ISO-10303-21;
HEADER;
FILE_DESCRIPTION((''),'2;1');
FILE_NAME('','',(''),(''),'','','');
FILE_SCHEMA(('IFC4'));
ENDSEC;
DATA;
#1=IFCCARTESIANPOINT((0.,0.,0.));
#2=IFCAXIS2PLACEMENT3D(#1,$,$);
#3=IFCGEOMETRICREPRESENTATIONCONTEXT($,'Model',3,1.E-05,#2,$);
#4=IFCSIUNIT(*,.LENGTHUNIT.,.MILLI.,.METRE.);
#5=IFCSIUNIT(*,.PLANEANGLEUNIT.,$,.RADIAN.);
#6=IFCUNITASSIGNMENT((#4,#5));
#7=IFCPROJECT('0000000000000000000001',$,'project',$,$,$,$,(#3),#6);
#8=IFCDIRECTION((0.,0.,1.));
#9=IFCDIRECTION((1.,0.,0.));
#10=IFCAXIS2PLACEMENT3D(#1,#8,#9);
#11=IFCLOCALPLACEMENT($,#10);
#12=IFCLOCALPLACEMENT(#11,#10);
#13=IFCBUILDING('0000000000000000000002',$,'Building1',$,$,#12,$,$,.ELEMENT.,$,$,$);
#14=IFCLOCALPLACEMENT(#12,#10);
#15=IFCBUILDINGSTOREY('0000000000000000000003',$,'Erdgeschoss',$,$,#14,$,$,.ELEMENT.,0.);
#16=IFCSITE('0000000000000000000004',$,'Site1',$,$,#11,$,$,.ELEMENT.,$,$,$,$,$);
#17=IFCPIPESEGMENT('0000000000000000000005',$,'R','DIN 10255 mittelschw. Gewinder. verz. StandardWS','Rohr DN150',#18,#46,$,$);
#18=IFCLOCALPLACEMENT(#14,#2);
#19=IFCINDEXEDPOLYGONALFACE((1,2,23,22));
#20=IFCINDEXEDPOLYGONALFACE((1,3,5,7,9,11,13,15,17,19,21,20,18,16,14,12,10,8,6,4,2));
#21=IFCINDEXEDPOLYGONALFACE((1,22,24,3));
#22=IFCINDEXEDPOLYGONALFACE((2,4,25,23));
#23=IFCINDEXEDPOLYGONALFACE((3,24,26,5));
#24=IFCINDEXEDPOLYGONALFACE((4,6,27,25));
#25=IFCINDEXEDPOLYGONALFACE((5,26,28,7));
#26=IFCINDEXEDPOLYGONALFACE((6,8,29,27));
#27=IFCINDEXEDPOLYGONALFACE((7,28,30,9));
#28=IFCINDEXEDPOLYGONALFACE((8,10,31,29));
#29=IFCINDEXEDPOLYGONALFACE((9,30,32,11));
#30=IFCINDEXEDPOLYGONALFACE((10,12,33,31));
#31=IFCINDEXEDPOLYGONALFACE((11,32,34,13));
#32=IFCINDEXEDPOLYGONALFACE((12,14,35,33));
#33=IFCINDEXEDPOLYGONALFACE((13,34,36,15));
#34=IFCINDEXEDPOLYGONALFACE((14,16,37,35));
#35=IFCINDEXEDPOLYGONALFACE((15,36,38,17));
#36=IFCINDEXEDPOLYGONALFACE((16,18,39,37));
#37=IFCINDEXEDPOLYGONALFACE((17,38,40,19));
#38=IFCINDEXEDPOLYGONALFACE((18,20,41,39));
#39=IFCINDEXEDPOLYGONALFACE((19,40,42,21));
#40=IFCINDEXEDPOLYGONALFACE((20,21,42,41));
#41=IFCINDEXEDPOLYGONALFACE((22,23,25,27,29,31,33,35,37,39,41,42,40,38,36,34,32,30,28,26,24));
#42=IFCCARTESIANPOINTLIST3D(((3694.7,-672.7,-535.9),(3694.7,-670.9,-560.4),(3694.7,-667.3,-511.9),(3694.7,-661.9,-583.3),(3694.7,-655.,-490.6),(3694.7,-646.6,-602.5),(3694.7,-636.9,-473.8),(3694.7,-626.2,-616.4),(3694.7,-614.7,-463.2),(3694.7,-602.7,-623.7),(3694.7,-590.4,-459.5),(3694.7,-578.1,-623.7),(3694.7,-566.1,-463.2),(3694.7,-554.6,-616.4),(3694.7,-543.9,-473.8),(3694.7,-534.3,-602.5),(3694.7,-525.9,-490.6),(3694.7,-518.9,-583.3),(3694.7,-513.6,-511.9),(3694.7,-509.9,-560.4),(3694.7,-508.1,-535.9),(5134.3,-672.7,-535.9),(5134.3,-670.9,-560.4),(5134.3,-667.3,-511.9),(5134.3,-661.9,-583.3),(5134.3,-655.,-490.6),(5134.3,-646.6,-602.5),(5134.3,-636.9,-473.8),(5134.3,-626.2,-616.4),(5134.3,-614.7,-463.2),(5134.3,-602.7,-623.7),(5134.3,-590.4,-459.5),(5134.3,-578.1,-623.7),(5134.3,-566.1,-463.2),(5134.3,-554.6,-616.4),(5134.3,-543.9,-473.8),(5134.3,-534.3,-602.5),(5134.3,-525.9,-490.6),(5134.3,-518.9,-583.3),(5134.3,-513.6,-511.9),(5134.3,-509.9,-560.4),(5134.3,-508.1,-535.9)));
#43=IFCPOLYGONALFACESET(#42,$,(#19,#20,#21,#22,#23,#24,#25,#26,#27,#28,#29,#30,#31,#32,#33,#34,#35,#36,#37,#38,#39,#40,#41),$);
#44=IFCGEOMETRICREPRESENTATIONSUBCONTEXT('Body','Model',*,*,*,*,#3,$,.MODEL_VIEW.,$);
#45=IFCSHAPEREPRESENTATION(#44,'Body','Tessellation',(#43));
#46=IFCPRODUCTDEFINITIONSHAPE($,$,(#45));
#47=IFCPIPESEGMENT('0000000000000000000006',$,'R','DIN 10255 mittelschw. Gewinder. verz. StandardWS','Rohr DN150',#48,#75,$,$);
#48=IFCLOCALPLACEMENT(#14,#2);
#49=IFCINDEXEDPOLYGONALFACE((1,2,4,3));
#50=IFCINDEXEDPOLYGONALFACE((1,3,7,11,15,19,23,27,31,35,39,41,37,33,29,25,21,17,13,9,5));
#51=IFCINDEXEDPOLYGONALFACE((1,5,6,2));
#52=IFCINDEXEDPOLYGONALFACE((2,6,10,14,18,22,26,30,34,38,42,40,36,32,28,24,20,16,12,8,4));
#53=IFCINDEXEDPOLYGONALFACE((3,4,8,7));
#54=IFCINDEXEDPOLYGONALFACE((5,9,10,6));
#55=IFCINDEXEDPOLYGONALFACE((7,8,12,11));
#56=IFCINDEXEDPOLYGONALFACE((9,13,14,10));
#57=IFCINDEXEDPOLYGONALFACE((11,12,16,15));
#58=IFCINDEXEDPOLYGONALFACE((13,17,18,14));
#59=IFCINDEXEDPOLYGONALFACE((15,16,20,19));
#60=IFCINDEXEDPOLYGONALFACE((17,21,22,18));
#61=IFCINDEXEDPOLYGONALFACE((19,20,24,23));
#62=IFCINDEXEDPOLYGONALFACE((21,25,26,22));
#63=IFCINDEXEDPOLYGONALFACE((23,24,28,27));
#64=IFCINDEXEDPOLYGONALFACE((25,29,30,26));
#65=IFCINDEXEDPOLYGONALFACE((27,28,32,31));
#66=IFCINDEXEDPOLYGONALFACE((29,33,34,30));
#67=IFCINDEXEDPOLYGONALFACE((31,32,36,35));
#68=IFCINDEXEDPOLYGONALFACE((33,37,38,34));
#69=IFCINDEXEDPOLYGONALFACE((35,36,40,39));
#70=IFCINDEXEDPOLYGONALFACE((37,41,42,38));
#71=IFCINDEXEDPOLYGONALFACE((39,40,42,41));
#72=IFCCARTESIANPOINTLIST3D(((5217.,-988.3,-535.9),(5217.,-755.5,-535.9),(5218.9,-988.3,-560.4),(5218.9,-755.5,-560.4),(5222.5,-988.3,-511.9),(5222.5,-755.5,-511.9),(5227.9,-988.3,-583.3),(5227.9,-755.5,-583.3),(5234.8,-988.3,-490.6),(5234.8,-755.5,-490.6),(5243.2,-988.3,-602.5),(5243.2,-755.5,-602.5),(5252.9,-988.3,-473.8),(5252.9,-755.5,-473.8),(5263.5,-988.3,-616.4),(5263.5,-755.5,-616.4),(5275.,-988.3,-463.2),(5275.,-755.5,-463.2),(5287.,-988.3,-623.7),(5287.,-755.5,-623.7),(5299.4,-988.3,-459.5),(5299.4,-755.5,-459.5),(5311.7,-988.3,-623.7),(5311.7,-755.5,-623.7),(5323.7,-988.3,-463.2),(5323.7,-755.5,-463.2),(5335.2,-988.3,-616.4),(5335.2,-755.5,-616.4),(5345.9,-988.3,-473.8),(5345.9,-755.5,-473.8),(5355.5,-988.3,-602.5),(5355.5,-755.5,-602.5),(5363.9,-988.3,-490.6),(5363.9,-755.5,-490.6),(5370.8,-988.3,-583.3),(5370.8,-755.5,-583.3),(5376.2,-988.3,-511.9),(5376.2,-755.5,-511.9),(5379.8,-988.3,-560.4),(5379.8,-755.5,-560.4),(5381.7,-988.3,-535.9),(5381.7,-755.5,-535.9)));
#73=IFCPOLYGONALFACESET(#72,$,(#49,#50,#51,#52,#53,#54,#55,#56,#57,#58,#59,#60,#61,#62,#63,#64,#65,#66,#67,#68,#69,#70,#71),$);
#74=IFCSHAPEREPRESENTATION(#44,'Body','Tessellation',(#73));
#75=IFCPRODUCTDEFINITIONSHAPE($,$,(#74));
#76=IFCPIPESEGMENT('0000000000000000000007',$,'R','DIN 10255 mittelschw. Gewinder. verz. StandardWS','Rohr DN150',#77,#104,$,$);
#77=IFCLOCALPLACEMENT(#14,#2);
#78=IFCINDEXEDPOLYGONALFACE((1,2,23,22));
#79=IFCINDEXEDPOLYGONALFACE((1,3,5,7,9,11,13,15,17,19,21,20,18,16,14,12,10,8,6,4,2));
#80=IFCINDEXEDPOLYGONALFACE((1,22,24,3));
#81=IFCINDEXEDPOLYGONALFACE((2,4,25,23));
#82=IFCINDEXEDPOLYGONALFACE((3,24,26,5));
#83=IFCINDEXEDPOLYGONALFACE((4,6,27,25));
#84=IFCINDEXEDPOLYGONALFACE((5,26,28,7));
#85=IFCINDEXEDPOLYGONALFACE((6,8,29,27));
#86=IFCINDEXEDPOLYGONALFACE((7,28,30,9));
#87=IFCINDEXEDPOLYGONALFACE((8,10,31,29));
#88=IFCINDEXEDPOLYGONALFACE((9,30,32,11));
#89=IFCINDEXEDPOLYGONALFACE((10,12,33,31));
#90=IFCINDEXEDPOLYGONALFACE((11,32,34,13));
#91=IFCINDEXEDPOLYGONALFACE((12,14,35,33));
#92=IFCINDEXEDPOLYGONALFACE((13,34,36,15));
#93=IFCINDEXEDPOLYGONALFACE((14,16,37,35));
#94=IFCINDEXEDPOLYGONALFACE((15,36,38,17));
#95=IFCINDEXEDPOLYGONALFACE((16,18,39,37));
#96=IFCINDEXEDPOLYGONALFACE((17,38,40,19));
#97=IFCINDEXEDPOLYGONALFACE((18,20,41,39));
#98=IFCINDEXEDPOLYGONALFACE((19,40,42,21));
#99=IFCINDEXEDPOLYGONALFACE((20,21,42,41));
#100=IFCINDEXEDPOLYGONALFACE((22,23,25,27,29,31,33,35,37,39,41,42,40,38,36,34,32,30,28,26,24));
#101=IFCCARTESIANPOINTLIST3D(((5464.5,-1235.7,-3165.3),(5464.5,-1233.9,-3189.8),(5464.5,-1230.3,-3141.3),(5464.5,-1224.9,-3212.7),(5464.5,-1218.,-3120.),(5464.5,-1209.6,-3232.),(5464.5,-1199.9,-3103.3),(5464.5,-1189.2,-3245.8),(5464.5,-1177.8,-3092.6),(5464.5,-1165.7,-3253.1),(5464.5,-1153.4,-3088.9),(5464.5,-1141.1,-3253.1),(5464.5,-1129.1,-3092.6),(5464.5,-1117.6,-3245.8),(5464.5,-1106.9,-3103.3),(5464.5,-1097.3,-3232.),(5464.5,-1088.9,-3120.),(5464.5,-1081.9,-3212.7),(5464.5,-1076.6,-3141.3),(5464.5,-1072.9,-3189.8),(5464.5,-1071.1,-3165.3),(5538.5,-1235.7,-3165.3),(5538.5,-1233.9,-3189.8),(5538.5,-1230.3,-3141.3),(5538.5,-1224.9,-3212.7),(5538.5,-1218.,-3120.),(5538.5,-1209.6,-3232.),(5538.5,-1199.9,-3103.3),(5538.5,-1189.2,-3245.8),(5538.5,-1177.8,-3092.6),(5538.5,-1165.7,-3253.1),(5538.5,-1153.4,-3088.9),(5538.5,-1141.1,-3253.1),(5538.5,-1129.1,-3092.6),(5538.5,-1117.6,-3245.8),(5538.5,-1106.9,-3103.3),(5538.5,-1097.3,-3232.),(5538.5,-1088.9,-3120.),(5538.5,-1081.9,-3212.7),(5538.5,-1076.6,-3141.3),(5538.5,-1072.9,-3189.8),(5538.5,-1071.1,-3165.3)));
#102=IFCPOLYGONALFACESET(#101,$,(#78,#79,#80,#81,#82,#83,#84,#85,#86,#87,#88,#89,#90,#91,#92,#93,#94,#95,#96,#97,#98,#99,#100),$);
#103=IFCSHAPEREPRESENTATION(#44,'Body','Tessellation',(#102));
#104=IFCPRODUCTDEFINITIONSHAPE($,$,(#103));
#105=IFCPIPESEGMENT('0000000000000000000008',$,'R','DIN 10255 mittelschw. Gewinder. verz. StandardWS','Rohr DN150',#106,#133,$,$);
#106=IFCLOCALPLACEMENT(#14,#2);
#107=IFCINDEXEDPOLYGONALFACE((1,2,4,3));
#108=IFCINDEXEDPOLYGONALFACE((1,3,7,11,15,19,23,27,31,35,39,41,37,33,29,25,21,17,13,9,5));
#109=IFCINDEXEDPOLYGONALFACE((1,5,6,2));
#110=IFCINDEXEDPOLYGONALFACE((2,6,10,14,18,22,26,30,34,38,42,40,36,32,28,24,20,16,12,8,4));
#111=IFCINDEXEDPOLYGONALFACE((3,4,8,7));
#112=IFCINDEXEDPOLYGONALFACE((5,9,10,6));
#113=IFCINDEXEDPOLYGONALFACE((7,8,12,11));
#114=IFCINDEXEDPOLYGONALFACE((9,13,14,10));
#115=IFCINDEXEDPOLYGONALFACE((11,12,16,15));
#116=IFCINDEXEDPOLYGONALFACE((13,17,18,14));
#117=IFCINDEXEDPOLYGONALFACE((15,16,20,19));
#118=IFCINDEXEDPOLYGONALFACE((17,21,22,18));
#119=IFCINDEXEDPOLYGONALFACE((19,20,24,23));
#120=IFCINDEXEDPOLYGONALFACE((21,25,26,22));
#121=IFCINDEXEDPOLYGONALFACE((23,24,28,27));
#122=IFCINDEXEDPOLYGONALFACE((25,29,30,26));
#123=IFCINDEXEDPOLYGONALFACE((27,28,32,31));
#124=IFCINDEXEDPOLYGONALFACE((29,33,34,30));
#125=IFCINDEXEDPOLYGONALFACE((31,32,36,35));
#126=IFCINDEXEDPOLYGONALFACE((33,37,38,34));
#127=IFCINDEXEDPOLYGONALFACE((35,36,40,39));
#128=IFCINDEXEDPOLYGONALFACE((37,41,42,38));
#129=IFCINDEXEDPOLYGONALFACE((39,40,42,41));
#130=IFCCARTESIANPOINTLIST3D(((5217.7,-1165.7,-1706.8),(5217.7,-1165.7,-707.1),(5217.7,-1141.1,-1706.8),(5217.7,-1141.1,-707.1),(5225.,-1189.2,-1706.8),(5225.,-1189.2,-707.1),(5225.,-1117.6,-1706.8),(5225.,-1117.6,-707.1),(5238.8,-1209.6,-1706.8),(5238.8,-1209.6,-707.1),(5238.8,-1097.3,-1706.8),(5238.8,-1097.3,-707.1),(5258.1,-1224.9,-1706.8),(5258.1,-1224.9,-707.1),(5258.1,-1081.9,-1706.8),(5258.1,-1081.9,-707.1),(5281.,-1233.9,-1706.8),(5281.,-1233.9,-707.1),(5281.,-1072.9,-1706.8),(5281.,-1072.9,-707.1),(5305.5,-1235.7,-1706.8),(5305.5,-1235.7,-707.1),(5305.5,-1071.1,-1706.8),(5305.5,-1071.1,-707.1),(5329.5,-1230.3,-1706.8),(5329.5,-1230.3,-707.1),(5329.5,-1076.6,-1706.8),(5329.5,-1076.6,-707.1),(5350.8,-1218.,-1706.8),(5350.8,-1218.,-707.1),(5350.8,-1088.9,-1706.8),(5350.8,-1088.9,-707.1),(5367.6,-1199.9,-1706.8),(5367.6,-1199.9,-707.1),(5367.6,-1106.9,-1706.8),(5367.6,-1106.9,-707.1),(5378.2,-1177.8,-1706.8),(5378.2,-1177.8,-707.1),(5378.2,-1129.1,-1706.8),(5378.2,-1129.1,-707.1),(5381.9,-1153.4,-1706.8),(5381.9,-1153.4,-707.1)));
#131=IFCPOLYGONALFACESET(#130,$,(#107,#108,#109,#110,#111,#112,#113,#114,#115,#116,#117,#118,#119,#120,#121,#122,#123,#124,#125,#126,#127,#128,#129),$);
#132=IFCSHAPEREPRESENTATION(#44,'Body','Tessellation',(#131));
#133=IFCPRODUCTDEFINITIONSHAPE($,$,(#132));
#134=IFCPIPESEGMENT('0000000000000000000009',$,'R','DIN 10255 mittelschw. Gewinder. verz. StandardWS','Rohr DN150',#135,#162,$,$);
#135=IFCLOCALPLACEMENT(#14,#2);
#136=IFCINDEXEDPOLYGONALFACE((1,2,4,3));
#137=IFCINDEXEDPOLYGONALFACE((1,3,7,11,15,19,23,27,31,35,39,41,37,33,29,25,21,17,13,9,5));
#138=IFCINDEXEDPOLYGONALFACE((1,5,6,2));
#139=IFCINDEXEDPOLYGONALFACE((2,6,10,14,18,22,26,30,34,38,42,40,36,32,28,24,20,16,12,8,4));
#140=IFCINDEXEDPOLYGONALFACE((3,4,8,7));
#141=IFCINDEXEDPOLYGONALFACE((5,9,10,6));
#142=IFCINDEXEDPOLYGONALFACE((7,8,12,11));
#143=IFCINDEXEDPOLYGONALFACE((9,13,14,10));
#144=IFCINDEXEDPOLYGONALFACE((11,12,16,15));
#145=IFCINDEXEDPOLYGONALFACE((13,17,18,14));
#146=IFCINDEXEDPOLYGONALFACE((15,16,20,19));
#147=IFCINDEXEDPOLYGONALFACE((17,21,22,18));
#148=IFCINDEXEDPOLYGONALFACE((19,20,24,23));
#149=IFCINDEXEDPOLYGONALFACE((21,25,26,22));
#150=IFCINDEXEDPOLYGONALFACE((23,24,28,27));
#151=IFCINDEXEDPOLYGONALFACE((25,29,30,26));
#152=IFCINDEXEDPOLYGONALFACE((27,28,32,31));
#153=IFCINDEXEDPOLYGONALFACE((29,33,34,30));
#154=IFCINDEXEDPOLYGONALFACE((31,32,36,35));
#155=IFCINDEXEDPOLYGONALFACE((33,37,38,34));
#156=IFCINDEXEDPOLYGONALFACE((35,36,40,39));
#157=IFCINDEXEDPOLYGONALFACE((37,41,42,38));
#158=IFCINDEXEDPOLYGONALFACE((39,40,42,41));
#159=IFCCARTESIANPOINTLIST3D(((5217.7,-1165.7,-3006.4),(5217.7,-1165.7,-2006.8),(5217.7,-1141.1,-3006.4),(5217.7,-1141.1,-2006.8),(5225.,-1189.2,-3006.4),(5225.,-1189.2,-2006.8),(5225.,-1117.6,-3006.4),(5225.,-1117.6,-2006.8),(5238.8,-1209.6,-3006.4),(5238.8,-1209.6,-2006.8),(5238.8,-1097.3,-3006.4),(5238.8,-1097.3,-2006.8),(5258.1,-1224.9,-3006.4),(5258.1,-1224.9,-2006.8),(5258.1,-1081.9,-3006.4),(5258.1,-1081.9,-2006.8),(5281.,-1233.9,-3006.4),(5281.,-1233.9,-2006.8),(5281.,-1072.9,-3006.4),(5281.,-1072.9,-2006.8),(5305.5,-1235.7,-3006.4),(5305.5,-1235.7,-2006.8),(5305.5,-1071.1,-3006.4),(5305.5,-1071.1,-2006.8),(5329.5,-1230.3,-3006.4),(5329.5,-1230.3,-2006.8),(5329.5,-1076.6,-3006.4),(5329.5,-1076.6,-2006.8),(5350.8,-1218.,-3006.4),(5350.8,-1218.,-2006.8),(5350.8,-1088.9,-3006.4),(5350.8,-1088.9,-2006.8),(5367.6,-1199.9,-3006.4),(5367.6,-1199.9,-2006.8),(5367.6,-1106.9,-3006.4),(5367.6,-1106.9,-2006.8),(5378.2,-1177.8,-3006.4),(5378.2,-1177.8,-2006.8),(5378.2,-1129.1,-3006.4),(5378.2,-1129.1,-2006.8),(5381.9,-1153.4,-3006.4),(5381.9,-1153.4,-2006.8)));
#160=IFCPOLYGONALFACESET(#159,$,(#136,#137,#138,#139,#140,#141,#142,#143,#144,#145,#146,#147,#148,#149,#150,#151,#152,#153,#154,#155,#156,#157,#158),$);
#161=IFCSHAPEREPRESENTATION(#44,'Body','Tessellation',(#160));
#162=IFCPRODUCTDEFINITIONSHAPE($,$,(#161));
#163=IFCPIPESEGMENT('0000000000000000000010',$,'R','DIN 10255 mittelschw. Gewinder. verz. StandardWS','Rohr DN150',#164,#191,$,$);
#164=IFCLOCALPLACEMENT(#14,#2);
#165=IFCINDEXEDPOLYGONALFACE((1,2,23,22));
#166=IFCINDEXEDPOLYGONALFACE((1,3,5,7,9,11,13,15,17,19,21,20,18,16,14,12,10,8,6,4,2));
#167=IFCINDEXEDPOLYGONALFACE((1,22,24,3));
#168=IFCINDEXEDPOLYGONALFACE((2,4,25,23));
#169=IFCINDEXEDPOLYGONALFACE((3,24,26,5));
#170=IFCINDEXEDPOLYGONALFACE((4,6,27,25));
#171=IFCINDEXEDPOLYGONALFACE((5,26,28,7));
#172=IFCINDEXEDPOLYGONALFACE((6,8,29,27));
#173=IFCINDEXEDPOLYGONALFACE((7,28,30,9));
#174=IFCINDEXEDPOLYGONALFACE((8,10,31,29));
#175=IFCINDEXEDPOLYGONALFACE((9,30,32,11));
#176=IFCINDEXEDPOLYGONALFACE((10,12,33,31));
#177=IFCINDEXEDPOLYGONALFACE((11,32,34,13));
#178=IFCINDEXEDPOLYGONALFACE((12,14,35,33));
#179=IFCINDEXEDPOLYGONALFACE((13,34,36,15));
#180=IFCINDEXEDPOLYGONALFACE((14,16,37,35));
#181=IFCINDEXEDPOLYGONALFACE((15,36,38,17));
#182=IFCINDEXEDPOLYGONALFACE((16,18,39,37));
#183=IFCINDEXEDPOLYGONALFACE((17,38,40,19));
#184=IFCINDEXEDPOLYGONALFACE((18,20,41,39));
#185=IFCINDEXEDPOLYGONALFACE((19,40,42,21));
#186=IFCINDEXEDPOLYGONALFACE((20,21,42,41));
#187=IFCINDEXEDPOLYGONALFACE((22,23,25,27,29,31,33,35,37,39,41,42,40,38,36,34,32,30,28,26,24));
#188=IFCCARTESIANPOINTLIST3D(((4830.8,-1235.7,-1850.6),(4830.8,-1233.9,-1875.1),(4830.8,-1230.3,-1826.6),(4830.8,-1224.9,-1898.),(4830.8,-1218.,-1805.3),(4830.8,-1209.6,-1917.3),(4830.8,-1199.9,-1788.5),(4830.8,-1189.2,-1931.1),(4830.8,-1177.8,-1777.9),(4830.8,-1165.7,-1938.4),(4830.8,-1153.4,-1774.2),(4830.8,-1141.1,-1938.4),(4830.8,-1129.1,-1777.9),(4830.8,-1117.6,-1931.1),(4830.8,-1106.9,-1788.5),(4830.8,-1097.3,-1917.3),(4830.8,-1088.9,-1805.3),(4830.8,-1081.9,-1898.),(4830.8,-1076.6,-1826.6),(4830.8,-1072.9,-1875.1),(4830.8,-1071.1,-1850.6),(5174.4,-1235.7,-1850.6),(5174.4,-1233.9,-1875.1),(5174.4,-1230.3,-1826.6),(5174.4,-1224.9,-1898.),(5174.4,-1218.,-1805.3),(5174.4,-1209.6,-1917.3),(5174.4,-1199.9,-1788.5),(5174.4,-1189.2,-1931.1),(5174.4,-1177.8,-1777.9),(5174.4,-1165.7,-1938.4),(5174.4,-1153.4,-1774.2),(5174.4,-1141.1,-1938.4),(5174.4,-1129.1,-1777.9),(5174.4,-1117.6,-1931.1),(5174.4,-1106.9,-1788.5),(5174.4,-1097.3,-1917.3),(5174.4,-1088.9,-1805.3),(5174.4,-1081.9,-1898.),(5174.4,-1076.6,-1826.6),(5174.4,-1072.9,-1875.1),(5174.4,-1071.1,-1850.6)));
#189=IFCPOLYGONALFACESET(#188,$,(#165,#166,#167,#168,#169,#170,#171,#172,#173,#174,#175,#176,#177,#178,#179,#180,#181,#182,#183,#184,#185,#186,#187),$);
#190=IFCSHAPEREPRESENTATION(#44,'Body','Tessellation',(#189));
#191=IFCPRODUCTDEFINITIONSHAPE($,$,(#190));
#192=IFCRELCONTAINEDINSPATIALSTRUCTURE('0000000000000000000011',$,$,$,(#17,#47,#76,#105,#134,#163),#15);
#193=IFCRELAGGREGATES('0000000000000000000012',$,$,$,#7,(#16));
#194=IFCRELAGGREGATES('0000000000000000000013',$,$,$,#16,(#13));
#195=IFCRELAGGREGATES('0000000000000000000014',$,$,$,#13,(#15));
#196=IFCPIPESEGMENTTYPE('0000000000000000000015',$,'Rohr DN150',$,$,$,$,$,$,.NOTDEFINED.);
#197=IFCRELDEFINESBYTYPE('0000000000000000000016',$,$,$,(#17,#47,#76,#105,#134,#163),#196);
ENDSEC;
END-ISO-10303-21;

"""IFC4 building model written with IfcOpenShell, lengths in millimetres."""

from ifc_helpers import new_model, si_unit, frame, origin, origin_with_axes, origin_2d_with_axis, place, context, subcontext, project, spatial, circle, extrude, type_object, element, save


model = new_model("IFC4")

# Units and contexts
model_context = context("Model", 3, precision=1e-05, world=origin())
body_context = subcontext(model_context, "Body", "Model", "MODEL_VIEW")
ifc_project = project(units=[si_unit("LENGTHUNIT", "METRE", prefix="MILLI"), si_unit("PLANEANGLEUNIT", "RADIAN")], contexts=[model_context])

# Site, building, storey
site_placement = place(None, origin_with_axes())
site = spatial("IfcSite", under=ifc_project, at=site_placement, Name="Site1", CompositionType="ELEMENT")
building_placement = place(site_placement, origin_with_axes())
building = spatial("IfcBuilding", under=site, at=building_placement, Name="Building1", CompositionType="ELEMENT")
storey_placement = place(building_placement, origin_with_axes())
storey = spatial("IfcBuildingStorey", under=building, at=storey_placement, Name="Erdgeschoss", CompositionType="ELEMENT", Elevation=0.0)

# Pipe segments
pipe_segment_type_1 = type_object("IfcPipeSegmentType", Name="Rohr DN150", PredefinedType="NOTDEFINED")
pipe_segment_1_placement = place(storey_placement, frame((4414.5, -590.3, -542.0), z_axis=(0.0, 0.0, 1.0), x_axis=(1.0, 0.0, 0.0)))
element("IfcPipeSegment", 1, at=pipe_segment_1_placement, inside=storey, type_object=pipe_segment_type_1, Name="R", Description="DIN 10255 mittelschw. Gewinder. verz. StandardWS", ObjectType="Rohr DN150", context=body_context, shape_type="SolidModel", body=[
    extrude(circle(Radius=82.5, at=origin_2d_with_axis()), frame((-719.8, -0.2, 0.0), z_axis=(1.0, 0.0, 0.0), x_axis=(0.0, 0.0, 1.0)), (0.0, 0.0, 1.0), 1439.6),
])
pipe_segment_2_placement = place(storey_placement, frame((5299.5, -871.9, -542.0), z_axis=(0.0, 0.0, 1.0), x_axis=(1.0, 0.0, 0.0)))
element("IfcPipeSegment", 2, at=pipe_segment_2_placement, inside=storey, type_object=pipe_segment_type_1, Name="R", Description="DIN 10255 mittelschw. Gewinder. verz. StandardWS", ObjectType="Rohr DN150", context=body_context, shape_type="SolidModel", body=[
    extrude(circle(Radius=82.5, at=origin_2d_with_axis()), frame((-0.2, 116.4, 0.0), z_axis=(0.0, -1.0, 0.0), x_axis=(0.0, 0.0, 1.0)), (0.0, 0.0, 1.0), 232.8),
])
pipe_segment_3_placement = place(storey_placement, frame((5501.5, -1153.6, -3171.5), z_axis=(0.0, 0.0, 1.0), x_axis=(1.0, 0.0, 0.0)))
element("IfcPipeSegment", 3, at=pipe_segment_3_placement, inside=storey, type_object=pipe_segment_type_1, Name="R", Description="DIN 10255 mittelschw. Gewinder. verz. StandardWS", ObjectType="Rohr DN150", context=body_context, shape_type="SolidModel", body=[
    extrude(circle(Radius=82.5, at=origin_2d_with_axis()), frame((37.0, 0.1, 0.0), z_axis=(-1.0, 0.0, 0.0), x_axis=(0.0, 0.0, 1.0)), (0.0, 0.0, 1.0), 74.0),
])
for number, where, z_axis, x_axis, name in (
    (4, (5299.4, -1153.3, -1206.9), (0.0, 0.0, 1.0), (1.0, 0.0, 0.0), "R"),
    (5, (5299.4, -1153.3, -2506.6), (0.0, 0.0, 1.0), (1.0, 0.0, 0.0), "R"),
):
    element("IfcPipeSegment", number, at=place(storey_placement, frame(where, z_axis=z_axis, x_axis=x_axis)), inside=storey, type_object=pipe_segment_type_1, Name=name, Description="DIN 10255 mittelschw. Gewinder. verz. StandardWS", ObjectType="Rohr DN150", context=body_context, shape_type="SolidModel", body=[
        extrude(circle(Radius=82.5, at=origin_2d_with_axis()), frame((0.0, -0.1, 499.8), z_axis=(0.0, 0.0, -1.0), x_axis=(1.0, 0.0, 0.0)), (0.0, 0.0, 1.0), 999.6),
    ])
pipe_segment_4_placement = place(storey_placement, frame((5002.6, -1153.6, -1856.8), z_axis=(0.0, 0.0, 1.0), x_axis=(1.0, 0.0, 0.0)))
element("IfcPipeSegment", 6, at=pipe_segment_4_placement, inside=storey, type_object=pipe_segment_type_1, Name="R", Description="DIN 10255 mittelschw. Gewinder. verz. StandardWS", ObjectType="Rohr DN150", context=body_context, shape_type="SolidModel", body=[
    extrude(circle(Radius=82.5, at=origin_2d_with_axis()), frame((171.8, 0.2, 0.0), z_axis=(-1.0, 0.0, 0.0), x_axis=(0.0, 0.0, 1.0)), (0.0, 0.0, 1.0), 343.6),
])

save(model, "model.ifc")
